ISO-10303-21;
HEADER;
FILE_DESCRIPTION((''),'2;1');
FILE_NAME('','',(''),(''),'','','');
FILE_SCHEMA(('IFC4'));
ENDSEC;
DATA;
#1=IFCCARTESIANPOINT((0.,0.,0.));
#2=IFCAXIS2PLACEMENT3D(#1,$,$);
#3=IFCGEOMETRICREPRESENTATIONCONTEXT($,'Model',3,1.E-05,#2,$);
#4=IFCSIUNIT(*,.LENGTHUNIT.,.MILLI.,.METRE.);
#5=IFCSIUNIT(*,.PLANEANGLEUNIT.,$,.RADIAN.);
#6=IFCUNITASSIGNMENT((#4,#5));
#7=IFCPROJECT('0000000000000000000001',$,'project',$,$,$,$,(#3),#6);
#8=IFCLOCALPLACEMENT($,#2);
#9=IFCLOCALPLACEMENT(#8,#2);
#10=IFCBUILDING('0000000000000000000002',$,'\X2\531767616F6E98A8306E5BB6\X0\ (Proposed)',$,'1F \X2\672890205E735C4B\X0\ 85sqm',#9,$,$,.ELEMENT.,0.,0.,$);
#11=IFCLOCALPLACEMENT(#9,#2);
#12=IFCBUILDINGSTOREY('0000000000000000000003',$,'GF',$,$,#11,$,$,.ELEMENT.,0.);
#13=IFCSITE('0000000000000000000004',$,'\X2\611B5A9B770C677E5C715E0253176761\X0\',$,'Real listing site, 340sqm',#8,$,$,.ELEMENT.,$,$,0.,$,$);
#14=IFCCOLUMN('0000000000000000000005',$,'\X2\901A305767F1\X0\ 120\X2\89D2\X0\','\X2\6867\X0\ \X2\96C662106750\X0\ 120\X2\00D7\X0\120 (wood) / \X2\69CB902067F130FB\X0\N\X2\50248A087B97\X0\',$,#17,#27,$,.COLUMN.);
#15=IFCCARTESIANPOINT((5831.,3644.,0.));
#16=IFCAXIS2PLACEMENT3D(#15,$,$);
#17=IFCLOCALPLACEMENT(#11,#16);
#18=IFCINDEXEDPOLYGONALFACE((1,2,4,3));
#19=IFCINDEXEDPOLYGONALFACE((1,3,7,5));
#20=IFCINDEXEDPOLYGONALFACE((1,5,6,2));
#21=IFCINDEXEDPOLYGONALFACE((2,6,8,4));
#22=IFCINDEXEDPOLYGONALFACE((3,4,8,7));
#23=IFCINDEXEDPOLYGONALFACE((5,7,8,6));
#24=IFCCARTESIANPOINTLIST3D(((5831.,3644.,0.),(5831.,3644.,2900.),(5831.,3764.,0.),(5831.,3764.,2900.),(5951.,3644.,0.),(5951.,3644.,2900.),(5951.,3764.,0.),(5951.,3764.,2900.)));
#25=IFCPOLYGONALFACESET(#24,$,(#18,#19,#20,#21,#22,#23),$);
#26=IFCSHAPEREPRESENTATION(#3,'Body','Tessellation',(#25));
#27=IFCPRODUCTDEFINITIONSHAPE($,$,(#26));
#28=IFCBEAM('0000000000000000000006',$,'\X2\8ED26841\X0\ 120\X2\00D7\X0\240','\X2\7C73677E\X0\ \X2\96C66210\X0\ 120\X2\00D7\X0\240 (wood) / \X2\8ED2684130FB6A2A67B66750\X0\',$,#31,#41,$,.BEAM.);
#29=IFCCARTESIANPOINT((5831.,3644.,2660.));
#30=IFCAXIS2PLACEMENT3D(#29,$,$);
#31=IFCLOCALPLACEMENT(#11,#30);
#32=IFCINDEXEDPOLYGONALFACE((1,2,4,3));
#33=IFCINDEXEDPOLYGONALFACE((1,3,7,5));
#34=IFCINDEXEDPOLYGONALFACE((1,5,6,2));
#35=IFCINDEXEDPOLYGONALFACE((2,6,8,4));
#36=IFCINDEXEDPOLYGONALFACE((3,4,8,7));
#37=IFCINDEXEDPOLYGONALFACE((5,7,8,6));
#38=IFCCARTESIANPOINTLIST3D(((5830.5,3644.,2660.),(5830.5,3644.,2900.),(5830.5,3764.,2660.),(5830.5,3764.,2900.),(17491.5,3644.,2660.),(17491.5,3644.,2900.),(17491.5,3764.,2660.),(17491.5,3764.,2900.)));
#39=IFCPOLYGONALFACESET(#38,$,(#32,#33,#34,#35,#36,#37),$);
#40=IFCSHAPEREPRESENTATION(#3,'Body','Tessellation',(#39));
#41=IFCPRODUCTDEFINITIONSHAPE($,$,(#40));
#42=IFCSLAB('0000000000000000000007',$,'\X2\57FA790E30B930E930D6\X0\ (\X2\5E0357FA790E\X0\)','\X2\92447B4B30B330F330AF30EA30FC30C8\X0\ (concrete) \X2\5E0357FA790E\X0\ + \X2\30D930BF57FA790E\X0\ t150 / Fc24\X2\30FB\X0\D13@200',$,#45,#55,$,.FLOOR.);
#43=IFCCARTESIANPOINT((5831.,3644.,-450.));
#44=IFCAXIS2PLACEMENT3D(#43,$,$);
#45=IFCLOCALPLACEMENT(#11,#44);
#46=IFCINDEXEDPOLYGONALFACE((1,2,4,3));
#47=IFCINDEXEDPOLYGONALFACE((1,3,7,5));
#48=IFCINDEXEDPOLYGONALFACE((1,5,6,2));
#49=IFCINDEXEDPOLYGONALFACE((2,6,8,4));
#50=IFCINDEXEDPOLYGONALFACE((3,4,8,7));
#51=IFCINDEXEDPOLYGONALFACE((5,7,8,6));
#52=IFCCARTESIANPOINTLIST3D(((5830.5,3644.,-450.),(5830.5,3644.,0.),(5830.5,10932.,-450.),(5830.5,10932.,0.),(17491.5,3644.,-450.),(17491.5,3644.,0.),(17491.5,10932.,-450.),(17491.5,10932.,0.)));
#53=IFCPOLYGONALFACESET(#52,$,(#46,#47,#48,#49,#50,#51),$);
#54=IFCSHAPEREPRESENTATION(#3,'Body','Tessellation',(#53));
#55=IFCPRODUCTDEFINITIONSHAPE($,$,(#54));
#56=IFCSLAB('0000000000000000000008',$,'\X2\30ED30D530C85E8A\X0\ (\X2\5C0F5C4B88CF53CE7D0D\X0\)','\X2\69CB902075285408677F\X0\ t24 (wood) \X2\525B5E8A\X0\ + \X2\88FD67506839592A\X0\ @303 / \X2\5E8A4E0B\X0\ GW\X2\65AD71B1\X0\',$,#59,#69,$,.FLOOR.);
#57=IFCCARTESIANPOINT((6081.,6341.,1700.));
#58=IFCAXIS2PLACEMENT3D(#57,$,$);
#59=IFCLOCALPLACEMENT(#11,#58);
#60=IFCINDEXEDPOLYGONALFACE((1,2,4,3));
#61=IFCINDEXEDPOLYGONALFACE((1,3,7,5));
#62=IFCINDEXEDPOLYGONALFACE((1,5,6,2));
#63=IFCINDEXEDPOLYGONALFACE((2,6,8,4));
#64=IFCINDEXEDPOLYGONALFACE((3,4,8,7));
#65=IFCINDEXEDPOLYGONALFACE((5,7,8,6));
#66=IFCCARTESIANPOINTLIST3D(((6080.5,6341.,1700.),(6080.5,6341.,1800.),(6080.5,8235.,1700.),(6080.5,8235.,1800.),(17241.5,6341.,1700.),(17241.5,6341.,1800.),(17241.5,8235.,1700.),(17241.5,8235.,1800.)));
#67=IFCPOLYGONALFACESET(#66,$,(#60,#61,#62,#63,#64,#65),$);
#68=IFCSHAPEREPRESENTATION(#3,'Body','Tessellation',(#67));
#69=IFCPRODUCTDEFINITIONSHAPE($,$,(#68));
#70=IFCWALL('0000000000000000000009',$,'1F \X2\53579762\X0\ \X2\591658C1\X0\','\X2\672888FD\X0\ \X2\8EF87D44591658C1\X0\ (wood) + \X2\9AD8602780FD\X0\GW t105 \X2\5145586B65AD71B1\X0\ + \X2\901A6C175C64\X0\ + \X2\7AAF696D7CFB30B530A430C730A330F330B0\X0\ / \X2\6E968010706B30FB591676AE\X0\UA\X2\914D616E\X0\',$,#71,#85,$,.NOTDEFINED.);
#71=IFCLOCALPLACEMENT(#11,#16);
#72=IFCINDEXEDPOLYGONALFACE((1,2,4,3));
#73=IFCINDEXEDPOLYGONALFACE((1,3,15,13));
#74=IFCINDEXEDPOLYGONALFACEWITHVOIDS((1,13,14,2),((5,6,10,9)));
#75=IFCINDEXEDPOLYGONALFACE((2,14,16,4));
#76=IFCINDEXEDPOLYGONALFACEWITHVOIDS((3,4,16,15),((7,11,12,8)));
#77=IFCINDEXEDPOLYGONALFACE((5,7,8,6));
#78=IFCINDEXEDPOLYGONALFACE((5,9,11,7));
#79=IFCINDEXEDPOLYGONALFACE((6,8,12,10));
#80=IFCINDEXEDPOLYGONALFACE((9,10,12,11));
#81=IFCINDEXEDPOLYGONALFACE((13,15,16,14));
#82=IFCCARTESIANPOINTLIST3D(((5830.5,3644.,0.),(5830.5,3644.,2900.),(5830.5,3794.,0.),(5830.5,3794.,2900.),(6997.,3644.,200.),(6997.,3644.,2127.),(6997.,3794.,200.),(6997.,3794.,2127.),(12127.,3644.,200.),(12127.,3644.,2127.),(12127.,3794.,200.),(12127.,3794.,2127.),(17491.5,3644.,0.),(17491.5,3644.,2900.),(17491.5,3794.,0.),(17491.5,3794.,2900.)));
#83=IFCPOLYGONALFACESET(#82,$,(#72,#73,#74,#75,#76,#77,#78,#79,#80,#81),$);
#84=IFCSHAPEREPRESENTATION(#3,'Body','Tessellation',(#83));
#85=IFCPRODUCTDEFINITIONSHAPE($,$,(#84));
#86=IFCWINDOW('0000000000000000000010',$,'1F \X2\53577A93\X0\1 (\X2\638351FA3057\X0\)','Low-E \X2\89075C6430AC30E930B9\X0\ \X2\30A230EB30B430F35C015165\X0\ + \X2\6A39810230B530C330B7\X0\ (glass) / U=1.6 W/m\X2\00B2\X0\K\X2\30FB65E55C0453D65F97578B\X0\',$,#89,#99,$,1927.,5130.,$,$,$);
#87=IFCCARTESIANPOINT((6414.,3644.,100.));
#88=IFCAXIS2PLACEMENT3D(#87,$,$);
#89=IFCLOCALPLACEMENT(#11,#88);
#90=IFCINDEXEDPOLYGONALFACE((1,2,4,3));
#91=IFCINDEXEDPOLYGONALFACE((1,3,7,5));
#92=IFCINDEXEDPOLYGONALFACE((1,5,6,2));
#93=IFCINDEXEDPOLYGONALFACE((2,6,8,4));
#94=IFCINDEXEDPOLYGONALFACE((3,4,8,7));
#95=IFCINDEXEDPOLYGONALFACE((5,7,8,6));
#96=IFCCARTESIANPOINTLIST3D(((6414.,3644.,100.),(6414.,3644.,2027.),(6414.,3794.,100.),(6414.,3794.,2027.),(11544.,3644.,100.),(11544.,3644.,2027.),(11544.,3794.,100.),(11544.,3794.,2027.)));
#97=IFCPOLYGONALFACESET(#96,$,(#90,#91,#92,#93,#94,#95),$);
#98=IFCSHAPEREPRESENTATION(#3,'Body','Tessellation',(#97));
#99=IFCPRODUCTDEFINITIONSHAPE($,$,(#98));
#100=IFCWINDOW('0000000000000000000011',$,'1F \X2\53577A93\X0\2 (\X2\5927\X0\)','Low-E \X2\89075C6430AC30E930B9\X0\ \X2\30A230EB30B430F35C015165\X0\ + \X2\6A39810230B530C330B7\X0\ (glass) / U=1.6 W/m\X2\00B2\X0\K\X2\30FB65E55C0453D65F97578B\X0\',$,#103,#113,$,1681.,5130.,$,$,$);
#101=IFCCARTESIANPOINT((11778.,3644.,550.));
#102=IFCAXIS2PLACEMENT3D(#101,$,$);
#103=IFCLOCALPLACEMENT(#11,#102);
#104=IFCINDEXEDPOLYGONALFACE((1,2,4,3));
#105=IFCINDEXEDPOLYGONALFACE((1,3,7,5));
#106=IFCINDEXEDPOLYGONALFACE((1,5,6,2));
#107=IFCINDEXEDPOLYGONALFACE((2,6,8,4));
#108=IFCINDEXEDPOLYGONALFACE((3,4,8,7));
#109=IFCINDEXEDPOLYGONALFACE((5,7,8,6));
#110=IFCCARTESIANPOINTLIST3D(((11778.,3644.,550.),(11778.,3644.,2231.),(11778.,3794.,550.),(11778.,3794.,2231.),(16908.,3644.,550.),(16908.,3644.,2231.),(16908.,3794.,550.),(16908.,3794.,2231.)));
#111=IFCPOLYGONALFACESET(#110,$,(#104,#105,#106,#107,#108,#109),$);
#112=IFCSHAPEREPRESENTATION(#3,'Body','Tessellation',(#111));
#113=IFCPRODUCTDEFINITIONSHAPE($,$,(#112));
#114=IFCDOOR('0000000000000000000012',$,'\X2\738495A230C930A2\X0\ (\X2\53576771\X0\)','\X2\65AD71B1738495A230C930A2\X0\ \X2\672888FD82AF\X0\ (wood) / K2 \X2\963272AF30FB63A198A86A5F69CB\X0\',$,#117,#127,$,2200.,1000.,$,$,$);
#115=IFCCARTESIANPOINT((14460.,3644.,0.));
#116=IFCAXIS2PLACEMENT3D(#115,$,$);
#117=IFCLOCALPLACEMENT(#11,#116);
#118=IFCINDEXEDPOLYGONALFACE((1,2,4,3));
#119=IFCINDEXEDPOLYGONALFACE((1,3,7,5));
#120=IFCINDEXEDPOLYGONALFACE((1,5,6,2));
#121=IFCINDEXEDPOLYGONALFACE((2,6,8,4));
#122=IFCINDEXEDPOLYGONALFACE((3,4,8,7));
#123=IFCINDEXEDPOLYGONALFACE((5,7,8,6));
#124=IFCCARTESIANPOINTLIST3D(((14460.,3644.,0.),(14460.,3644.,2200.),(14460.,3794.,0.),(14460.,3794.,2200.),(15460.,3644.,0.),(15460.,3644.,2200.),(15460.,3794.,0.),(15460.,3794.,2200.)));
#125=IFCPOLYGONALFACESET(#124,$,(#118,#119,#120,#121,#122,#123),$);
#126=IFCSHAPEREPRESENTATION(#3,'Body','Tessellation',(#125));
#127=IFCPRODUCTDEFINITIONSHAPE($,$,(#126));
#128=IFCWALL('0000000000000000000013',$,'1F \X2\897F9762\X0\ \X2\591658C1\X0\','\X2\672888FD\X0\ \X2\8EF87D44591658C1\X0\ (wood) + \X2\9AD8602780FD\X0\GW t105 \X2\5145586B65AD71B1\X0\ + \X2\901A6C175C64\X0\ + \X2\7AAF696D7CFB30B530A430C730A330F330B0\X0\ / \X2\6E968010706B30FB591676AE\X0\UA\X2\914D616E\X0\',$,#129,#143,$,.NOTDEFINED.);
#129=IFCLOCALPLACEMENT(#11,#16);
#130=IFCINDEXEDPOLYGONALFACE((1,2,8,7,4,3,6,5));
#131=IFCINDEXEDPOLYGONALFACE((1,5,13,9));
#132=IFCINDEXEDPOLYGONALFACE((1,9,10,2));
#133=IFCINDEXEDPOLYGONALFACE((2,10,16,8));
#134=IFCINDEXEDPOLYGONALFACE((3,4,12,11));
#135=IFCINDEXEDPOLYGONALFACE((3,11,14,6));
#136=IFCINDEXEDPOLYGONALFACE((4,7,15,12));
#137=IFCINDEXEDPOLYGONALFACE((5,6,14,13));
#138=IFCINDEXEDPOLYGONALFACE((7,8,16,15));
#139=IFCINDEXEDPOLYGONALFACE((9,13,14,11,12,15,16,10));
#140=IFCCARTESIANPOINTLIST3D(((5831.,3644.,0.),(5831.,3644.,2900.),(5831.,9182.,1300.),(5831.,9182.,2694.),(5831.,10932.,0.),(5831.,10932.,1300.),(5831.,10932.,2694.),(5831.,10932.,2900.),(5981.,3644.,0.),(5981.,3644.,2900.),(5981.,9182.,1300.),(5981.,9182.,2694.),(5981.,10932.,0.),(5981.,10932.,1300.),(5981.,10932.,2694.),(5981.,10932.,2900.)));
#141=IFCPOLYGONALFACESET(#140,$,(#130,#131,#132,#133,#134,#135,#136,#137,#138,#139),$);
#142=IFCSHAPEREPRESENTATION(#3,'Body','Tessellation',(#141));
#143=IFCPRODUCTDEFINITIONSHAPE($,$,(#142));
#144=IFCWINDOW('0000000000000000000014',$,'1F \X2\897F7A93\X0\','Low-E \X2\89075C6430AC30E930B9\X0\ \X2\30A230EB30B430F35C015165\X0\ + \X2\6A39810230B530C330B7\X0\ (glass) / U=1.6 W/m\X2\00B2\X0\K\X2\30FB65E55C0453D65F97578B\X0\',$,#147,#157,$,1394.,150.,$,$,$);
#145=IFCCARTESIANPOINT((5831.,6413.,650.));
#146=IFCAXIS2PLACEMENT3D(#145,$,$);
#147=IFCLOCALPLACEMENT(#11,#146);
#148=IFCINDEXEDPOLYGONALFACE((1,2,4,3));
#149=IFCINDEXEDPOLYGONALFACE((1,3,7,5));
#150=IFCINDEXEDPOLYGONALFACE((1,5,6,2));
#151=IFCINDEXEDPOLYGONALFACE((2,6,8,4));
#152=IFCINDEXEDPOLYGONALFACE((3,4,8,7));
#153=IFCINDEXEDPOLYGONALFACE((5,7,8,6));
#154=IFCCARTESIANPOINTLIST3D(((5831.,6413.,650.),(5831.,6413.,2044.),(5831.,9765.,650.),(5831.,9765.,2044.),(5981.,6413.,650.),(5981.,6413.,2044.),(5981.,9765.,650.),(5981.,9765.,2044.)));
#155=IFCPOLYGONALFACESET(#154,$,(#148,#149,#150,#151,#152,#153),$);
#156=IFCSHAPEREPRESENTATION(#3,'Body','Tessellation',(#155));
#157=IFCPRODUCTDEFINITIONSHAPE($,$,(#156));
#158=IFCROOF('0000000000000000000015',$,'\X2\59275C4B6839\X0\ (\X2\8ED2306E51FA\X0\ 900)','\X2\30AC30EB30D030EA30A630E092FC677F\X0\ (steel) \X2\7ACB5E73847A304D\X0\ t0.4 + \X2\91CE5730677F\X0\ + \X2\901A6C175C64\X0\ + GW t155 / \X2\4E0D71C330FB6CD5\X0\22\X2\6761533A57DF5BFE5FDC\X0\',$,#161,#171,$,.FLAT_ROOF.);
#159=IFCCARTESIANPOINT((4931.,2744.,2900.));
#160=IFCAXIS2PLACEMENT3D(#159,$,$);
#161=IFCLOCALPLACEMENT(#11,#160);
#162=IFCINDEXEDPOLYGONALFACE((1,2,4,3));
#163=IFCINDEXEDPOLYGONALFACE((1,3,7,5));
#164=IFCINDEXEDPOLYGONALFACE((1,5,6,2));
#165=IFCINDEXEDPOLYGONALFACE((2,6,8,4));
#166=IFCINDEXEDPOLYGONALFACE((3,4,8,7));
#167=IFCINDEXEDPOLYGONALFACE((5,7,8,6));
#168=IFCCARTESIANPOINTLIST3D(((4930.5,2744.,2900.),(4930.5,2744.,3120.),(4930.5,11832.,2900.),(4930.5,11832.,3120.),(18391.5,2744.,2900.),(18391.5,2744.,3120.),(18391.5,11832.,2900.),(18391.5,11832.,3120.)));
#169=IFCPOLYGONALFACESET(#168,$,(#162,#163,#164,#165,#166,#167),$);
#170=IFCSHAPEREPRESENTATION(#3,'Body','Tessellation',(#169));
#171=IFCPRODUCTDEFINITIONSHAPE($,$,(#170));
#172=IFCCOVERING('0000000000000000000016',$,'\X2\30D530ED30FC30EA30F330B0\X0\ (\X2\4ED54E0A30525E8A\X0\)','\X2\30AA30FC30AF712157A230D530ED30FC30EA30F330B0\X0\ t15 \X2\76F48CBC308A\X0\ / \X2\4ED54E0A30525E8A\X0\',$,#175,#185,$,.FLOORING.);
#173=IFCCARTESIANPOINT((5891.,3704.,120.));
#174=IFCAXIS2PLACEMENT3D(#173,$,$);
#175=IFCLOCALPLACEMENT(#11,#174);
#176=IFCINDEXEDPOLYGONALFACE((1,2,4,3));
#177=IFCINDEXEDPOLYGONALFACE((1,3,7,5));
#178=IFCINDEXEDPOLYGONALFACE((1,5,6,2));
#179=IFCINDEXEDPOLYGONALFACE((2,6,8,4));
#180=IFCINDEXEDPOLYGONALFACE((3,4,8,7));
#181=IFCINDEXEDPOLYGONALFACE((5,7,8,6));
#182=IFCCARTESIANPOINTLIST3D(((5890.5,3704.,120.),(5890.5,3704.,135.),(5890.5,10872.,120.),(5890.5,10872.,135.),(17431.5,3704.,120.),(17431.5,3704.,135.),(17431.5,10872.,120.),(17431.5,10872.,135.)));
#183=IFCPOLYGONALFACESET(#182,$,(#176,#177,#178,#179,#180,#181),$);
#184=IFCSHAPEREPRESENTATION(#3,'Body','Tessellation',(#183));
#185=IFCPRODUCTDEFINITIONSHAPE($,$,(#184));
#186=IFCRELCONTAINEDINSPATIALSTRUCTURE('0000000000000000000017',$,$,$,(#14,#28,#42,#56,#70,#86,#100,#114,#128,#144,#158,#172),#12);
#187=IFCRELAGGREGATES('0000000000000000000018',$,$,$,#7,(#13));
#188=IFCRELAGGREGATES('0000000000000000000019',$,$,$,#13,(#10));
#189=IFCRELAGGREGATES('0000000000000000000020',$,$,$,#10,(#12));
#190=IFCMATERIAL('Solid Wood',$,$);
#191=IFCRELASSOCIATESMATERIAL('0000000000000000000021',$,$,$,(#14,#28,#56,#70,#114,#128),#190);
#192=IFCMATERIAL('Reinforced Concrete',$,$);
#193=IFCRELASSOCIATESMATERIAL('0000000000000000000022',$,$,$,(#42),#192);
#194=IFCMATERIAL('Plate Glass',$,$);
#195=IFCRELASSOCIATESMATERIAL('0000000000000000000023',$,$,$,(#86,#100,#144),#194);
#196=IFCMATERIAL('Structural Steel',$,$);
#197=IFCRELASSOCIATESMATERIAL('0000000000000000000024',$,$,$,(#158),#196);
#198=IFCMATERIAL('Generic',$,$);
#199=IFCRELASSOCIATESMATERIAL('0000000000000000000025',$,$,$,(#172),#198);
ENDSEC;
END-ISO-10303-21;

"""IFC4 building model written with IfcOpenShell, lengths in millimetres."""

from ifc_helpers import new_model, si_unit, frame, frame_2d, origin, place, context, project, spatial, rectangle, extrude, material, element, fill, save


model = new_model("IFC4")

# Units and contexts
model_context = context("Model", 3, precision=1e-05, world=origin())
ifc_project = project(units=[si_unit("LENGTHUNIT", "METRE", prefix="MILLI"), si_unit("PLANEANGLEUNIT", "RADIAN")], contexts=[model_context])

# Site, building, storey
site_placement = place(None, origin())
site = spatial("IfcSite", under=ifc_project, at=site_placement, Name="愛媛県松山市北条", ObjectType="Real listing site, 340sqm", CompositionType="ELEMENT", RefElevation=0.0)
building_placement = place(site_placement, origin())
building = spatial("IfcBuilding", under=site, at=building_placement, Name="北条潮風の家 (Proposed)", ObjectType="1F 木造平屋 85sqm", CompositionType="ELEMENT", ElevationOfRefHeight=0.0, ElevationOfTerrain=0.0)
storey_placement = place(building_placement, origin())
storey = spatial("IfcBuildingStorey", under=building, at=storey_placement, Name="GF", CompositionType="ELEMENT", Elevation=0.0)

# Column
ifc_material_1 = material(Name="Solid Wood")
column_1_placement = place(storey_placement, frame((5831.0, 3644.0, 0.0)))
element("IfcColumn", 1, at=column_1_placement, inside=storey, material=ifc_material_1, Name="通し柱 120角", Description="桧 集成材 120×120 (wood) / 構造柱・N値計算", PredefinedType="COLUMN", context=model_context, shape_type="SweptSolid", body=[
    extrude(rectangle(XDim=120.0, YDim=120.0, at=frame_2d((60.0, 60.0))), frame((5831.0, 3644.0, 0.0)), (0.0, 0.0, 1.0), 2900.0),
])

# Beam
beam_1_placement = place(storey_placement, frame((5831.0, 3644.0, 2660.0)))
element("IfcBeam", 2, at=beam_1_placement, inside=storey, material=ifc_material_1, Name="軒桁 120×240", Description="米松 集成 120×240 (wood) / 軒桁・横架材", PredefinedType="BEAM", context=model_context, shape_type="SweptSolid", body=[
    extrude(rectangle(XDim=11661.0, YDim=120.0, at=frame_2d((5830.0, 60.0))), frame((5831.0, 3644.0, 2660.0)), (0.0, 0.0, 1.0), 240.0),
])

# Slabs
ifc_material_2 = material(Name="Reinforced Concrete")
slab_1_placement = place(storey_placement, frame((5831.0, 3644.0, -450.0)))
element("IfcSlab", 3, at=slab_1_placement, inside=storey, material=ifc_material_2, Name="基礎スラブ (布基礎)", Description="鉄筋コンクリート (concrete) 布基礎 + ベタ基礎 t150 / Fc24・D13@200", PredefinedType="FLOOR", context=model_context, shape_type="SweptSolid", body=[
    extrude(rectangle(XDim=11661.0, YDim=7288.0, at=frame_2d((5830.0, 3644.0))), frame((5831.0, 3644.0, -450.0)), (0.0, 0.0, 1.0), 450.0),
])
slab_2_placement = place(storey_placement, frame((6081.0, 6341.0, 1700.0)))
element("IfcSlab", 4, at=slab_2_placement, inside=storey, material=ifc_material_1, Name="ロフト床 (小屋裏収納)", Description="構造用合板 t24 (wood) 剛床 + 製材根太 @303 / 床下 GW断熱", PredefinedType="FLOOR", context=model_context, shape_type="SweptSolid", body=[
    extrude(rectangle(XDim=11161.0, YDim=1894.0, at=frame_2d((5580.0, 947.0))), frame((6081.0, 6341.0, 1700.0)), (0.0, 0.0, 1.0), 100.0),
])

# Wall, openings, windows, door
wall_1_placement = place(storey_placement, frame((5831.0, 3644.0, 0.0)))
wall_1 = element("IfcWall", 5, at=wall_1_placement, inside=storey, material=ifc_material_1, Name="1F 南面 外壁", Description="木製 軸組外壁 (wood) + 高性能GW t105 充填断熱 + 通気層 + 窯業系サイディング / 準耐火・外皮UA配慮", PredefinedType="NOTDEFINED", context=model_context, shape_type="SweptSolid", body=[
    extrude(rectangle(XDim=11661.0, YDim=150.0, at=frame_2d((5830.0, 75.0))), frame((5831.0, 3644.0, 0.0)), (0.0, 0.0, 1.0), 2900.0),
])
opening_1_placement = place(storey_placement, frame((6414.0, 3644.0, 100.0)))
opening_1 = element("IfcOpeningElement", 6, at=opening_1_placement, cuts=wall_1, PredefinedType="NOTDEFINED", context=model_context, shape_type="SweptSolid", body=[
    extrude(rectangle(XDim=5130.0, YDim=150.0, at=frame_2d((2565.0, 75.0))), frame((6414.0, 3644.0, 100.0)), (0.0, 0.0, 1.0), 1927.0),
])
opening_2_placement = place(storey_placement, frame((11778.0, 3644.0, 550.0)))
opening_2 = element("IfcOpeningElement", 7, at=opening_2_placement, cuts=wall_1, PredefinedType="NOTDEFINED", context=model_context, shape_type="SweptSolid", body=[
    extrude(rectangle(XDim=5130.0, YDim=150.0, at=frame_2d((2565.0, 75.0))), frame((11778.0, 3644.0, 550.0)), (0.0, 0.0, 1.0), 1681.0),
])
opening_3_placement = place(storey_placement, frame((14460.0, 3644.0, 0.0)))
opening_3 = element("IfcOpeningElement", 8, at=opening_3_placement, cuts=wall_1, PredefinedType="NOTDEFINED", context=model_context, shape_type="SweptSolid", body=[
    extrude(rectangle(XDim=1000.0, YDim=150.0, at=frame_2d((500.0, 75.0))), frame((14460.0, 3644.0, 0.0)), (0.0, 0.0, 1.0), 2200.0),
])
ifc_material_3 = material(Name="Plate Glass")
window_1_placement = place(storey_placement, frame((6414.0, 3644.0, 100.0)))
window_1 = element("IfcWindow", 9, at=window_1_placement, inside=storey, material=ifc_material_3, Name="1F 南窓1 (掃出し)", Description="Low-E 複層ガラス アルゴン封入 + 樹脂サッシ (glass) / U=1.6 W/m²K・日射取得型", OverallHeight=1927.0, OverallWidth=5130.0, context=model_context, shape_type="SweptSolid", body=[
    extrude(rectangle(XDim=5130.0, YDim=150.0, at=frame_2d((2565.0, 75.0))), frame((6414.0, 3644.0, 100.0)), (0.0, 0.0, 1.0), 1927.0),
])
fill(opening_1, window_1)
window_2_placement = place(storey_placement, frame((11778.0, 3644.0, 550.0)))
window_2 = element("IfcWindow", 10, at=window_2_placement, inside=storey, material=ifc_material_3, Name="1F 南窓2 (大)", Description="Low-E 複層ガラス アルゴン封入 + 樹脂サッシ (glass) / U=1.6 W/m²K・日射取得型", OverallHeight=1681.0, OverallWidth=5130.0, context=model_context, shape_type="SweptSolid", body=[
    extrude(rectangle(XDim=5130.0, YDim=150.0, at=frame_2d((2565.0, 75.0))), frame((11778.0, 3644.0, 550.0)), (0.0, 0.0, 1.0), 1681.0),
])
fill(opening_2, window_2)
door_placement = place(storey_placement, frame((14460.0, 3644.0, 0.0)))
door = element("IfcDoor", 11, at=door_placement, inside=storey, material=ifc_material_1, Name="玄関ドア (南東)", Description="断熱玄関ドア 木製芯 (wood) / K2 防犯・採風機構", OverallHeight=2200.0, OverallWidth=1000.0, context=model_context, shape_type="SweptSolid", body=[
    extrude(rectangle(XDim=1000.0, YDim=150.0, at=frame_2d((500.0, 75.0))), frame((14460.0, 3644.0, 0.0)), (0.0, 0.0, 1.0), 2200.0),
])
fill(opening_3, door)

# Wall, opening, window
wall_2_placement = place(storey_placement, frame((5831.0, 3644.0, 0.0)))
wall_2 = element("IfcWall", 12, at=wall_2_placement, inside=storey, material=ifc_material_1, Name="1F 西面 外壁", Description="木製 軸組外壁 (wood) + 高性能GW t105 充填断熱 + 通気層 + 窯業系サイディング / 準耐火・外皮UA配慮", PredefinedType="NOTDEFINED", context=model_context, shape_type="SweptSolid", body=[
    extrude(rectangle(XDim=150.0, YDim=7288.0, at=frame_2d((75.0, 3644.0))), frame((5831.0, 3644.0, 0.0)), (0.0, 0.0, 1.0), 2900.0),
])
opening_4_placement = place(storey_placement, frame((5831.0, 6413.0, 650.0)))
opening_4 = element("IfcOpeningElement", 13, at=opening_4_placement, cuts=wall_2, PredefinedType="NOTDEFINED", context=model_context, shape_type="SweptSolid", body=[
    extrude(rectangle(XDim=150.0, YDim=3352.0, at=frame_2d((75.0, 1676.0))), frame((5831.0, 6413.0, 650.0)), (0.0, 0.0, 1.0), 1394.0),
])
window_3_placement = place(storey_placement, frame((5831.0, 6413.0, 650.0)))
window_3 = element("IfcWindow", 14, at=window_3_placement, inside=storey, material=ifc_material_3, Name="1F 西窓", Description="Low-E 複層ガラス アルゴン封入 + 樹脂サッシ (glass) / U=1.6 W/m²K・日射取得型", OverallHeight=1394.0, OverallWidth=150.0, context=model_context, shape_type="SweptSolid", body=[
    extrude(rectangle(XDim=150.0, YDim=3352.0, at=frame_2d((75.0, 1676.0))), frame((5831.0, 6413.0, 650.0)), (0.0, 0.0, 1.0), 1394.0),
])
fill(opening_4, window_3)

# Roof
ifc_material_4 = material(Name="Structural Steel")
roof_placement = place(storey_placement, frame((4931.0, 2744.0, 2900.0)))
element("IfcRoof", 15, at=roof_placement, inside=storey, material=ifc_material_4, Name="大屋根 (軒の出 900)", Description="ガルバリウム鋼板 (steel) 立平葺き t0.4 + 野地板 + 通気層 + GW t155 / 不燃・法22条区域対応", PredefinedType="FLAT_ROOF", context=model_context, shape_type="SweptSolid", body=[
    extrude(rectangle(XDim=13461.0, YDim=9088.0, at=frame_2d((6730.0, 4544.0))), frame((4931.0, 2744.0, 2900.0)), (0.0, 0.0, 1.0), 220.0),
])

# Covering
ifc_material_5 = material(Name="Generic")
covering_1_placement = place(storey_placement, frame((5891.0, 3704.0, 120.0)))
element("IfcCovering", 16, at=covering_1_placement, inside=storey, material=ifc_material_5, Name="フローリング (仕上げ床)", Description="オーク無垢フローリング t15 直貼り / 仕上げ床", PredefinedType="FLOORING", context=model_context, shape_type="SweptSolid", body=[
    extrude(rectangle(XDim=11541.0, YDim=7168.0, at=frame_2d((5770.0, 3584.0))), frame((5891.0, 3704.0, 120.0)), (0.0, 0.0, 1.0), 15.0),
])

save(model, "model.ifc")
